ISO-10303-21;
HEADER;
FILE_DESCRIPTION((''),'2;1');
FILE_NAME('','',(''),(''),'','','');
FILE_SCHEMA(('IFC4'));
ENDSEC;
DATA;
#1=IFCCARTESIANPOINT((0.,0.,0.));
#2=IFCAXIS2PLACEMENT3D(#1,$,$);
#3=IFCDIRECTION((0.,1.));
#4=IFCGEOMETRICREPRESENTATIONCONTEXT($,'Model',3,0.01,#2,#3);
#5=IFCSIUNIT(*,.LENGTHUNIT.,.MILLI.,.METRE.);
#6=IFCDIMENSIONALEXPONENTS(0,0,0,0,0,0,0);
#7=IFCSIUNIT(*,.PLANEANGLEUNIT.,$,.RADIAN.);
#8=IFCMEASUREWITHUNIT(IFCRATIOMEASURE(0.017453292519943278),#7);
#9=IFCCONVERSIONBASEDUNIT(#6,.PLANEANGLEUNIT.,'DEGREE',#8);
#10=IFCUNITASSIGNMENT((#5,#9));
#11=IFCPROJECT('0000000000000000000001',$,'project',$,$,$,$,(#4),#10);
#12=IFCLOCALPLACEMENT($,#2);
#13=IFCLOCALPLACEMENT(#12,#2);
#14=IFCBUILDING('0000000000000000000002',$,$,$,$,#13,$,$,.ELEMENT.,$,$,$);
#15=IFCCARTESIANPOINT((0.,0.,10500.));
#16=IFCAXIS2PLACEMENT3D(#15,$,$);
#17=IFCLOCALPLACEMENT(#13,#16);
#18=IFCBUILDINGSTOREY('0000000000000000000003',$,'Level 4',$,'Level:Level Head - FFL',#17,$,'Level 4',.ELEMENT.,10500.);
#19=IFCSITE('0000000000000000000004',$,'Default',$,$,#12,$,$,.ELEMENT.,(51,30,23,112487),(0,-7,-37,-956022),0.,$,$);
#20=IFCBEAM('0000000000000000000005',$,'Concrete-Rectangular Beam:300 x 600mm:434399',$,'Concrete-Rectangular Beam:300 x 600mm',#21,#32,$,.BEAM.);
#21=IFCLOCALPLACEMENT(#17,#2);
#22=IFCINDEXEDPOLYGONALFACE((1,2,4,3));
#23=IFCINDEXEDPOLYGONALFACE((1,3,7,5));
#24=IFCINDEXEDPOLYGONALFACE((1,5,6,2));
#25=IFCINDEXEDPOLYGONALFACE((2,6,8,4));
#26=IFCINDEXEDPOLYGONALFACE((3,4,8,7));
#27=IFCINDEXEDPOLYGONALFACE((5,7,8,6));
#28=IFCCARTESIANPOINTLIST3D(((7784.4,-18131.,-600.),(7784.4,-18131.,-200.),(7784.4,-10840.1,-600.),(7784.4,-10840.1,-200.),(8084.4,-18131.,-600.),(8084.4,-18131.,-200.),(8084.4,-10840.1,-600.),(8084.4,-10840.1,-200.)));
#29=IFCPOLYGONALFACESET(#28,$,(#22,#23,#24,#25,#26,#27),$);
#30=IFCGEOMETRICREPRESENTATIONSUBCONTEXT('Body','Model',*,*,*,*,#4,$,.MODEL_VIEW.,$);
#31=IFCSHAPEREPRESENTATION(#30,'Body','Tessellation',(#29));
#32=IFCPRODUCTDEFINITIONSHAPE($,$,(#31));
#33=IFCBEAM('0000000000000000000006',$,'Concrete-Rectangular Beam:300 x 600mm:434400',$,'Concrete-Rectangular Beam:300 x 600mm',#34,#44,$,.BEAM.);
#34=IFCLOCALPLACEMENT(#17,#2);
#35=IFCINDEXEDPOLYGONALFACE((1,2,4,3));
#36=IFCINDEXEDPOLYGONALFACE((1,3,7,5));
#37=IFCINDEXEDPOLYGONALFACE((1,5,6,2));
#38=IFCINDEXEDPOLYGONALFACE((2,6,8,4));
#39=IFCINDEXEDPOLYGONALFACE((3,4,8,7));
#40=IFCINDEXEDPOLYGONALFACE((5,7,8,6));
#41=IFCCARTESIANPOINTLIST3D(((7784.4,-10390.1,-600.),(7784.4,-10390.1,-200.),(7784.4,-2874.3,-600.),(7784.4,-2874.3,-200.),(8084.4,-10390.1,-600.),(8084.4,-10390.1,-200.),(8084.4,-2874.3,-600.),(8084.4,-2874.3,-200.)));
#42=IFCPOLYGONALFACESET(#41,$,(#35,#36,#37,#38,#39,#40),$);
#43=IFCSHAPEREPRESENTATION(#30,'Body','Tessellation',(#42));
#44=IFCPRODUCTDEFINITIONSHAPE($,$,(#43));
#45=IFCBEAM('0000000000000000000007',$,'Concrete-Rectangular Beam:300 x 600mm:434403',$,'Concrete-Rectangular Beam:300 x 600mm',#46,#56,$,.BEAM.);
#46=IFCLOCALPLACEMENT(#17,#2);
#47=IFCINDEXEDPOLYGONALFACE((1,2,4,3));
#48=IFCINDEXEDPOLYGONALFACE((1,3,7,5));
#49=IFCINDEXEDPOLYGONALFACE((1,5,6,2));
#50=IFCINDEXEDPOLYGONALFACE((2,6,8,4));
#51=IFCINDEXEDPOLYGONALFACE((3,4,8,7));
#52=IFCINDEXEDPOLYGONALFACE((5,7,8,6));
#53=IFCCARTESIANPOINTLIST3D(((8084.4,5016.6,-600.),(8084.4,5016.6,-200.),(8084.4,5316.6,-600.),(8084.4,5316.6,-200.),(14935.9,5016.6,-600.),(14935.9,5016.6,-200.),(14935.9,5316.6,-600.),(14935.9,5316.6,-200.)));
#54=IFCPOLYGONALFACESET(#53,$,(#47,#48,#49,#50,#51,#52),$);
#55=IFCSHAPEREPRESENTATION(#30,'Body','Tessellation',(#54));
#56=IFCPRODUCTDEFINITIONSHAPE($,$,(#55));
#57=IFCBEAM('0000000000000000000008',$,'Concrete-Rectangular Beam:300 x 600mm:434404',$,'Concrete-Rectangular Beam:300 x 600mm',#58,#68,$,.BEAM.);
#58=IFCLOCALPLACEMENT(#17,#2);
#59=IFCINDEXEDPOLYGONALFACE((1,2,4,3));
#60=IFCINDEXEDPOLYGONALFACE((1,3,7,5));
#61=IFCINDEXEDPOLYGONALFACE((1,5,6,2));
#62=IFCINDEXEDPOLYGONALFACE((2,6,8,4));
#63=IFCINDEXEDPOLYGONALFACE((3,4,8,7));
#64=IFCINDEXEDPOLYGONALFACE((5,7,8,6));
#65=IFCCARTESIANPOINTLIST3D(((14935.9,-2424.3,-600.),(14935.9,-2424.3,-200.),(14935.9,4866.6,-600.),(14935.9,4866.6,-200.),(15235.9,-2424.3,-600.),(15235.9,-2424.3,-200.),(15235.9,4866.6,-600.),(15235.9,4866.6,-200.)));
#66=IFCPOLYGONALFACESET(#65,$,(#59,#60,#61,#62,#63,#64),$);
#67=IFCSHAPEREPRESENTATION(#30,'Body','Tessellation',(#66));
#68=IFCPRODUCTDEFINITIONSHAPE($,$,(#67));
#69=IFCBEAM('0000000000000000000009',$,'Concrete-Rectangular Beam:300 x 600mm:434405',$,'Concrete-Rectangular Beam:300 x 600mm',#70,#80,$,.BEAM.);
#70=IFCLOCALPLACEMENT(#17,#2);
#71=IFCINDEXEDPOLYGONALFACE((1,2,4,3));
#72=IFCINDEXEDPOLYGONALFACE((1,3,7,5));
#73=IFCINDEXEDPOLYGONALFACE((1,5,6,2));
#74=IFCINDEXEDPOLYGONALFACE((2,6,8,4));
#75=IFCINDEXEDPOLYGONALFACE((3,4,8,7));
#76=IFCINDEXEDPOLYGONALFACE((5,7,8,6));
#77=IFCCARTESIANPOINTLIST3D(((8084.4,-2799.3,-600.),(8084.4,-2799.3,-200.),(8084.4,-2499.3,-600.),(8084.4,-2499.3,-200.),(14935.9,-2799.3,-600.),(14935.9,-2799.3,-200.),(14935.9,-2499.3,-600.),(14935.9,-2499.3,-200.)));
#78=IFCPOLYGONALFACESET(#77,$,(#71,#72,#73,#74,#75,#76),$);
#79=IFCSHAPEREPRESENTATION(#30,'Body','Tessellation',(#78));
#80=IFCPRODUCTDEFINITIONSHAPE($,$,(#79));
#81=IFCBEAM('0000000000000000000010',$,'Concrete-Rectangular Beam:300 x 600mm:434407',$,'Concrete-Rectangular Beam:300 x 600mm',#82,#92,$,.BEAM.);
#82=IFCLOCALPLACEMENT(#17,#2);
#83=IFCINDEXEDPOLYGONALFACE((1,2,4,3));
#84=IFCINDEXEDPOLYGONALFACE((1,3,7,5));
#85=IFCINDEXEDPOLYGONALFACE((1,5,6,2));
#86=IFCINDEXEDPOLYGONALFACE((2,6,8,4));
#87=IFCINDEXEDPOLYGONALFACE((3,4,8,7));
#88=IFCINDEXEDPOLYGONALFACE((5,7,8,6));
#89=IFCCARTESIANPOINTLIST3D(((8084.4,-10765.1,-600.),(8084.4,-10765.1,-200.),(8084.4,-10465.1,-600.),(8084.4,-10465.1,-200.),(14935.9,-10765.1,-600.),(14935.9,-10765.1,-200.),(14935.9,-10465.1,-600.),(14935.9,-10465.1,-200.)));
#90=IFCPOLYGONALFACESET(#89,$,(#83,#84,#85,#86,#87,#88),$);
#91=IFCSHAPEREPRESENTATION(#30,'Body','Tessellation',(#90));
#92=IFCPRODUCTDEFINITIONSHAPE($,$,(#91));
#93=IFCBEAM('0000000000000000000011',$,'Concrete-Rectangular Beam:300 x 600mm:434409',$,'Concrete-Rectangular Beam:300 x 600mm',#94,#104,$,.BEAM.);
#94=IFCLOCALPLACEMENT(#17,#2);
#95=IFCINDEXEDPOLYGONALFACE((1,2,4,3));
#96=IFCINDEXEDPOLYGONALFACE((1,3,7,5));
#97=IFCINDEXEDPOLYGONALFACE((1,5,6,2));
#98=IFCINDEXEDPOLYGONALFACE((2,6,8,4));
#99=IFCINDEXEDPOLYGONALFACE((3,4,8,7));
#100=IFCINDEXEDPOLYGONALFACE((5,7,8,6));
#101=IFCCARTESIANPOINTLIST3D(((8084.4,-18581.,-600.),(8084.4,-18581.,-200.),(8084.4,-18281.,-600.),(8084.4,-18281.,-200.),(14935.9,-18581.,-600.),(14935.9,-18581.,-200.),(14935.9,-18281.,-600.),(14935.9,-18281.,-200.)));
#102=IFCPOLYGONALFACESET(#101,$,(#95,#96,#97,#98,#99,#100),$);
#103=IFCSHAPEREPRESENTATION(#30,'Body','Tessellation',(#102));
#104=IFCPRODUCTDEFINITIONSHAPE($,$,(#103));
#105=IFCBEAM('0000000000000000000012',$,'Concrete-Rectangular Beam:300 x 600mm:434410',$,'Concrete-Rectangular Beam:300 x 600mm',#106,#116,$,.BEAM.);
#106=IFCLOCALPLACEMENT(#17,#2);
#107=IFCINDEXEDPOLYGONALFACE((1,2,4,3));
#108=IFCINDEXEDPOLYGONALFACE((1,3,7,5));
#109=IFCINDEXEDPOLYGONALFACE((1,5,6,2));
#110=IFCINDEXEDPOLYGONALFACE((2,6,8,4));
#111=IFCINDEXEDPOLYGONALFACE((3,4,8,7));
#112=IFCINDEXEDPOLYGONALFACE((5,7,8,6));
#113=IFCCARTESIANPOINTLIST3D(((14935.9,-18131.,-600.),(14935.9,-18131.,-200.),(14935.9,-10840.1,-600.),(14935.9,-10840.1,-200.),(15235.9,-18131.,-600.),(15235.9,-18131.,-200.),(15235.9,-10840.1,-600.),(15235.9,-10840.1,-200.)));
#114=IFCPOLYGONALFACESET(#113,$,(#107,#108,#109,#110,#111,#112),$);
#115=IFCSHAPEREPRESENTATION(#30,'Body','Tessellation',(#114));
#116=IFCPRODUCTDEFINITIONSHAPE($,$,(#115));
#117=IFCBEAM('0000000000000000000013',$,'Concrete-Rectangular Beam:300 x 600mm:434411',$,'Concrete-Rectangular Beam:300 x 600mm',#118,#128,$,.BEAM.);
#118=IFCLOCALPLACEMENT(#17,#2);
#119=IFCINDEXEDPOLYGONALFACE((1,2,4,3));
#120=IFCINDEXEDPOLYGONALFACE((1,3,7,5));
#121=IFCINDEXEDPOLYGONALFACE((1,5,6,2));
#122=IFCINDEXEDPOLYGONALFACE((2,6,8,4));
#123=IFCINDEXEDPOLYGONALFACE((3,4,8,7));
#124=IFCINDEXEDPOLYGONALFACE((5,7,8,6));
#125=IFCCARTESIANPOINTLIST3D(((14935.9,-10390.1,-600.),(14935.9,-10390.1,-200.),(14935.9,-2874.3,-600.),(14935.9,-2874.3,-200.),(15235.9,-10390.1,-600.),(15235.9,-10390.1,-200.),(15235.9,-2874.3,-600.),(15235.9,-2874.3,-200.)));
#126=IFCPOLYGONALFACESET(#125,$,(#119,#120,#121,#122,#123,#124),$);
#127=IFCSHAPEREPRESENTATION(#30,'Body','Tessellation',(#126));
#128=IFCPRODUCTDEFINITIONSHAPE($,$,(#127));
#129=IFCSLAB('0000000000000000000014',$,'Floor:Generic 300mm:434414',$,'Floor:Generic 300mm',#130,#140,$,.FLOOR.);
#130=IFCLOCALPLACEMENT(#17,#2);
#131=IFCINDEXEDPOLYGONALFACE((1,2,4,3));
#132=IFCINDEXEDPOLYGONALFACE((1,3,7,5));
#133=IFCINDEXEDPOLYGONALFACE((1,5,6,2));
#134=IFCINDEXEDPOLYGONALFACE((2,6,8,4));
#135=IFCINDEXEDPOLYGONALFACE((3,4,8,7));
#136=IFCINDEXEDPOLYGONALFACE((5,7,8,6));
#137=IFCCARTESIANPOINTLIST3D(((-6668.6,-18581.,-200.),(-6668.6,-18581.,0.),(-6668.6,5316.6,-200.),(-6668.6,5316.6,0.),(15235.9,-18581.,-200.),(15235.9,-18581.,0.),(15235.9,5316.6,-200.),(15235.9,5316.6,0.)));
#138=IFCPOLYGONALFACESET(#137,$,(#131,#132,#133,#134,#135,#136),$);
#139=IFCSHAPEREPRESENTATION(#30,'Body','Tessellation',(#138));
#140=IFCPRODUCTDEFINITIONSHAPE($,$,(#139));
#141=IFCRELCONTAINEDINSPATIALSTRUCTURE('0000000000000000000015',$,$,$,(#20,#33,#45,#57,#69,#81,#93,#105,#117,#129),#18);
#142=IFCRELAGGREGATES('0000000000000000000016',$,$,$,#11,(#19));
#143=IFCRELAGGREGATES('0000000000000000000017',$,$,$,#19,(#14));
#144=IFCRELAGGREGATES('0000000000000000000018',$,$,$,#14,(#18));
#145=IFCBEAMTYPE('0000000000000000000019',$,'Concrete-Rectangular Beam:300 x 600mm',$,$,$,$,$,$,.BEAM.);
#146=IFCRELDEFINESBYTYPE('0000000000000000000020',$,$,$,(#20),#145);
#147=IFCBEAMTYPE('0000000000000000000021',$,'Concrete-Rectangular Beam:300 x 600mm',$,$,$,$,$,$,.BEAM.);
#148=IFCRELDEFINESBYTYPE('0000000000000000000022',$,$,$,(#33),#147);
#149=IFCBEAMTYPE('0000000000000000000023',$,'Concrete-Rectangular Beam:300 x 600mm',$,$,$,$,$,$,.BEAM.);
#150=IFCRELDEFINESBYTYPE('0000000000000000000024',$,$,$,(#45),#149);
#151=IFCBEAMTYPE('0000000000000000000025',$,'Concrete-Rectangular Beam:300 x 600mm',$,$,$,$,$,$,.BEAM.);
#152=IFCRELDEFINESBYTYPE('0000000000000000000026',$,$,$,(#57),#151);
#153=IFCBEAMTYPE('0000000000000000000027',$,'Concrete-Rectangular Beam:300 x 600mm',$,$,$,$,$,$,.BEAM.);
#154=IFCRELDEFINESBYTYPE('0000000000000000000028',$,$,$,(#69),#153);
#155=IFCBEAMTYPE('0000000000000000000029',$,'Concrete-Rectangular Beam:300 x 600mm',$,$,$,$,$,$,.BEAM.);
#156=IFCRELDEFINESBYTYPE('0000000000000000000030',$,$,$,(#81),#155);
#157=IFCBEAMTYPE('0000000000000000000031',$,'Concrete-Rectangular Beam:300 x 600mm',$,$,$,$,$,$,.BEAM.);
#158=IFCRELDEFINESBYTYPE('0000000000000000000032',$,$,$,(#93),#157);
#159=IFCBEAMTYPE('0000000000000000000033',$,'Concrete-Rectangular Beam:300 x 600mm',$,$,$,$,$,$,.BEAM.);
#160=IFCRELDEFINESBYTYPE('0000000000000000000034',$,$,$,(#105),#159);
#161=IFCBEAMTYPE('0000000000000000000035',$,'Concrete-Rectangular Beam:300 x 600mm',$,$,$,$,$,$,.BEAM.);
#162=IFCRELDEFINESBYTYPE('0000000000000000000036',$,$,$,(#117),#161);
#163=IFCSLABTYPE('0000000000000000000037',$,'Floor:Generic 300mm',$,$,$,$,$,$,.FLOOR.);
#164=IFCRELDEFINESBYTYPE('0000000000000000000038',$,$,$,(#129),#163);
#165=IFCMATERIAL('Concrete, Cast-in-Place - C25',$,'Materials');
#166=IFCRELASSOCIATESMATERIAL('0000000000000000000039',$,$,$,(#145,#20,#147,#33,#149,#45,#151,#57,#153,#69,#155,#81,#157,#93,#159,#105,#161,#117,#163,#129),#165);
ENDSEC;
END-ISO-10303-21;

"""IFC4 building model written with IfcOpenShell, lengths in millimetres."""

from ifc_helpers import new_model, entity, si_unit, converted_unit, direction, frame, origin, place, context, subcontext, project, spatial, indexed_curve, outline, extrude, source, transform, mapped, material, type_object, type_shapes, element, save


model = new_model("IFC4")

# Units and contexts
model_context = context("Model", 3, precision=0.01, world=origin(), true_north=direction((0.0, 1.0)))
body_context = subcontext(model_context, "Body", "Model", "MODEL_VIEW")
ifc_project = project(units=[si_unit("LENGTHUNIT", "METRE", prefix="MILLI"), converted_unit("PLANEANGLEUNIT", "DEGREE", entity("IfcRatioMeasure", 0.017453292519943278), si_unit("PLANEANGLEUNIT", "RADIAN"), dimensions=[0, 0, 0, 0, 0, 0, 0])], contexts=[model_context])

# Site, building, storey
site_placement = place(None, origin())
site = spatial("IfcSite", under=ifc_project, at=site_placement, Name="Default", CompositionType="ELEMENT", RefLatitude=(51, 30, 23, 112487), RefLongitude=(0, -7, -37, -956022), RefElevation=0.0)
building_placement = place(site_placement, origin())
building = spatial("IfcBuilding", under=site, at=building_placement, CompositionType="ELEMENT")
storey_placement = place(building_placement, frame((0.0, 0.0, 10500.0)))
storey = spatial("IfcBuildingStorey", under=building, at=storey_placement, Name="Level 4", ObjectType="Level:Level Head - FFL", LongName="Level 4", CompositionType="ELEMENT", Elevation=10500.0)

# Beams
ifc_material = material(Name="Concrete, Cast-in-Place - C25", Category="Materials")
beam_type_1 = type_object("IfcBeamType", Name="Concrete-Rectangular Beam:300 x 600mm", PredefinedType="BEAM", material=ifc_material)
shared_shape_1 = source(origin(), body_context, "Body", "SweptSolid", [
    extrude(outline(indexed_curve([(-150.0, -200.0), (150.0, -200.0), (150.0, 200.0), (-150.0, 200.0), (-150.0, -200.0)], self_intersect=False)), frame((7934.4, -18131.0, 10100.0), z_axis=(0.0, 1.0, 0.0), x_axis=(-1.0, 0.0, 0.0)), (0.0, 0.0, 1.0), 7290.9),
])
type_shapes(beam_type_1, [shared_shape_1])
beam_1_placement = place(storey_placement, frame((0.0, 0.0, -10500.0)))
element("IfcBeam", 1, at=beam_1_placement, inside=storey, type_object=beam_type_1, material=ifc_material, Name="Concrete-Rectangular Beam:300 x 600mm:434399", ObjectType="Concrete-Rectangular Beam:300 x 600mm", PredefinedType="BEAM", context=body_context, shape_type="MappedRepresentation", body=[
    mapped(shared_shape_1, transform((0.0, 0.0, 0.0), scale=1.0)),
])
beam_type_2 = type_object("IfcBeamType", Name="Concrete-Rectangular Beam:300 x 600mm", PredefinedType="BEAM", material=ifc_material)
shared_shape_2 = source(origin(), body_context, "Body", "SweptSolid", [
    extrude(outline(indexed_curve([(-150.0, -200.0), (150.0, -200.0), (150.0, 200.0), (-150.0, 200.0), (-150.0, -200.0)], self_intersect=False)), frame((7934.4, -10390.1, 10100.0), z_axis=(0.0, 1.0, 0.0), x_axis=(-1.0, 0.0, 0.0)), (0.0, 0.0, 1.0), 7515.9),
])
type_shapes(beam_type_2, [shared_shape_2])
beam_2_placement = place(storey_placement, frame((0.0, 0.0, -10500.0)))
element("IfcBeam", 2, at=beam_2_placement, inside=storey, type_object=beam_type_2, material=ifc_material, Name="Concrete-Rectangular Beam:300 x 600mm:434400", ObjectType="Concrete-Rectangular Beam:300 x 600mm", PredefinedType="BEAM", context=body_context, shape_type="MappedRepresentation", body=[
    mapped(shared_shape_2, transform((0.0, 0.0, 0.0), scale=1.0)),
])
beam_type_3 = type_object("IfcBeamType", Name="Concrete-Rectangular Beam:300 x 600mm", PredefinedType="BEAM", material=ifc_material)
shared_shape_3 = source(origin(), body_context, "Body", "SweptSolid", [
    extrude(outline(indexed_curve([(-200.0, -150.0), (200.0, -150.0), (200.0, 150.0), (-200.0, 150.0), (-200.0, -150.0)], self_intersect=False)), frame((8084.4, 5166.6, 10100.0), z_axis=(1.0, 0.0, 0.0), x_axis=(0.0, 0.0, -1.0)), (0.0, 0.0, 1.0), 6851.5),
])
type_shapes(beam_type_3, [shared_shape_3])
beam_3_placement = place(storey_placement, frame((0.0, 0.0, -10500.0)))
element("IfcBeam", 3, at=beam_3_placement, inside=storey, type_object=beam_type_3, material=ifc_material, Name="Concrete-Rectangular Beam:300 x 600mm:434403", ObjectType="Concrete-Rectangular Beam:300 x 600mm", PredefinedType="BEAM", context=body_context, shape_type="MappedRepresentation", body=[
    mapped(shared_shape_3, transform((0.0, 0.0, 0.0), scale=1.0)),
])
beam_type_4 = type_object("IfcBeamType", Name="Concrete-Rectangular Beam:300 x 600mm", PredefinedType="BEAM", material=ifc_material)
shared_shape_4 = source(origin(), body_context, "Body", "SweptSolid", [
    extrude(outline(indexed_curve([(-150.0, -200.0), (150.0, -200.0), (150.0, 200.0), (-150.0, 200.0), (-150.0, -200.0)], self_intersect=False)), frame((15085.9, 4866.6, 10100.0), z_axis=(0.0, -1.0, 0.0), x_axis=(-1.0, 0.0, 0.0)), (0.0, 0.0, 1.0), 7290.9),
])
type_shapes(beam_type_4, [shared_shape_4])
beam_4_placement = place(storey_placement, frame((0.0, 0.0, -10500.0)))
element("IfcBeam", 4, at=beam_4_placement, inside=storey, type_object=beam_type_4, material=ifc_material, Name="Concrete-Rectangular Beam:300 x 600mm:434404", ObjectType="Concrete-Rectangular Beam:300 x 600mm", PredefinedType="BEAM", context=body_context, shape_type="MappedRepresentation", body=[
    mapped(shared_shape_4, transform((0.0, 0.0, 0.0), scale=1.0)),
])
beam_type_5 = type_object("IfcBeamType", Name="Concrete-Rectangular Beam:300 x 600mm", PredefinedType="BEAM", material=ifc_material)
shared_shape_5 = source(origin(), body_context, "Body", "SweptSolid", [
    extrude(outline(indexed_curve([(-200.0, -150.0), (200.0, -150.0), (200.0, 150.0), (-200.0, 150.0), (-200.0, -150.0)], self_intersect=False)), frame((14935.9, -2649.3, 10100.0), z_axis=(-1.0, 0.0, 0.0), x_axis=(0.0, 0.0, -1.0)), (0.0, 0.0, 1.0), 6851.5),
])
type_shapes(beam_type_5, [shared_shape_5])
beam_5_placement = place(storey_placement, frame((0.0, 0.0, -10500.0)))
element("IfcBeam", 5, at=beam_5_placement, inside=storey, type_object=beam_type_5, material=ifc_material, Name="Concrete-Rectangular Beam:300 x 600mm:434405", ObjectType="Concrete-Rectangular Beam:300 x 600mm", PredefinedType="BEAM", context=body_context, shape_type="MappedRepresentation", body=[
    mapped(shared_shape_5, transform((0.0, 0.0, 0.0), scale=1.0)),
])
beam_type_6 = type_object("IfcBeamType", Name="Concrete-Rectangular Beam:300 x 600mm", PredefinedType="BEAM", material=ifc_material)
shared_shape_6 = source(origin(), body_context, "Body", "SweptSolid", [
    extrude(outline(indexed_curve([(-200.0, -150.0), (200.0, -150.0), (200.0, 150.0), (-200.0, 150.0), (-200.0, -150.0)], self_intersect=False)), frame((14935.9, -10615.1, 10100.0), z_axis=(-1.0, 0.0, 0.0), x_axis=(0.0, 0.0, -1.0)), (0.0, 0.0, 1.0), 6851.5),
])
type_shapes(beam_type_6, [shared_shape_6])
beam_6_placement = place(storey_placement, frame((0.0, 0.0, -10500.0)))
element("IfcBeam", 6, at=beam_6_placement, inside=storey, type_object=beam_type_6, material=ifc_material, Name="Concrete-Rectangular Beam:300 x 600mm:434407", ObjectType="Concrete-Rectangular Beam:300 x 600mm", PredefinedType="BEAM", context=body_context, shape_type="MappedRepresentation", body=[
    mapped(shared_shape_6, transform((0.0, 0.0, 0.0), scale=1.0)),
])
beam_type_7 = type_object("IfcBeamType", Name="Concrete-Rectangular Beam:300 x 600mm", PredefinedType="BEAM", material=ifc_material)
shared_shape_7 = source(origin(), body_context, "Body", "SweptSolid", [
    extrude(outline(indexed_curve([(-200.0, -150.0), (200.0, -150.0), (200.0, 150.0), (-200.0, 150.0), (-200.0, -150.0)], self_intersect=False)), frame((14935.9, -18431.0, 10100.0), z_axis=(-1.0, 0.0, 0.0), x_axis=(0.0, 0.0, -1.0)), (0.0, 0.0, 1.0), 6851.5),
])
type_shapes(beam_type_7, [shared_shape_7])
beam_7_placement = place(storey_placement, frame((0.0, 0.0, -10500.0)))
element("IfcBeam", 7, at=beam_7_placement, inside=storey, type_object=beam_type_7, material=ifc_material, Name="Concrete-Rectangular Beam:300 x 600mm:434409", ObjectType="Concrete-Rectangular Beam:300 x 600mm", PredefinedType="BEAM", context=body_context, shape_type="MappedRepresentation", body=[
    mapped(shared_shape_7, transform((0.0, 0.0, 0.0), scale=1.0)),
])
beam_type_8 = type_object("IfcBeamType", Name="Concrete-Rectangular Beam:300 x 600mm", PredefinedType="BEAM", material=ifc_material)
shared_shape_8 = source(origin(), body_context, "Body", "SweptSolid", [
    extrude(outline(indexed_curve([(-150.0, -200.0), (150.0, -200.0), (150.0, 200.0), (-150.0, 200.0), (-150.0, -200.0)], self_intersect=False)), frame((15085.9, -18131.0, 10100.0), z_axis=(0.0, 1.0, 0.0), x_axis=(-1.0, 0.0, 0.0)), (0.0, 0.0, 1.0), 7290.9),
])
type_shapes(beam_type_8, [shared_shape_8])
beam_8_placement = place(storey_placement, frame((0.0, 0.0, -10500.0)))
element("IfcBeam", 8, at=beam_8_placement, inside=storey, type_object=beam_type_8, material=ifc_material, Name="Concrete-Rectangular Beam:300 x 600mm:434410", ObjectType="Concrete-Rectangular Beam:300 x 600mm", PredefinedType="BEAM", context=body_context, shape_type="MappedRepresentation", body=[
    mapped(shared_shape_8, transform((0.0, 0.0, 0.0), scale=1.0)),
])
beam_type_9 = type_object("IfcBeamType", Name="Concrete-Rectangular Beam:300 x 600mm", PredefinedType="BEAM", material=ifc_material)
shared_shape_9 = source(origin(), body_context, "Body", "SweptSolid", [
    extrude(outline(indexed_curve([(-150.0, -200.0), (150.0, -200.0), (150.0, 200.0), (-150.0, 200.0), (-150.0, -200.0)], self_intersect=False)), frame((15085.9, -10390.1, 10100.0), z_axis=(0.0, 1.0, 0.0), x_axis=(-1.0, 0.0, 0.0)), (0.0, 0.0, 1.0), 7515.9),
])
type_shapes(beam_type_9, [shared_shape_9])
beam_9_placement = place(storey_placement, frame((0.0, 0.0, -10500.0)))
element("IfcBeam", 9, at=beam_9_placement, inside=storey, type_object=beam_type_9, material=ifc_material, Name="Concrete-Rectangular Beam:300 x 600mm:434411", ObjectType="Concrete-Rectangular Beam:300 x 600mm", PredefinedType="BEAM", context=body_context, shape_type="MappedRepresentation", body=[
    mapped(shared_shape_9, transform((0.0, 0.0, 0.0), scale=1.0)),
])

# Slab
slab_type = type_object("IfcSlabType", Name="Floor:Generic 300mm", PredefinedType="FLOOR", material=ifc_material)
slab_placement = place(storey_placement, origin())
element("IfcSlab", 10, at=slab_placement, inside=storey, type_object=slab_type, material=ifc_material, Name="Floor:Generic 300mm:434414", ObjectType="Floor:Generic 300mm", PredefinedType="FLOOR", context=body_context, shape_type="SweptSolid", body=[
    extrude(outline(indexed_curve([(-11948.8, -10952.2), (11948.8, -10952.2), (11948.8, 10952.2), (-11948.8, 10952.2), (-11948.8, -10952.2)], self_intersect=False)), frame((4283.6, -6632.2, 0.0), z_axis=(0.0, 0.0, -1.0), x_axis=(0.0, 1.0, 0.0)), (0.0, 0.0, 1.0), 200.0),
])

save(model, "model.ifc")
